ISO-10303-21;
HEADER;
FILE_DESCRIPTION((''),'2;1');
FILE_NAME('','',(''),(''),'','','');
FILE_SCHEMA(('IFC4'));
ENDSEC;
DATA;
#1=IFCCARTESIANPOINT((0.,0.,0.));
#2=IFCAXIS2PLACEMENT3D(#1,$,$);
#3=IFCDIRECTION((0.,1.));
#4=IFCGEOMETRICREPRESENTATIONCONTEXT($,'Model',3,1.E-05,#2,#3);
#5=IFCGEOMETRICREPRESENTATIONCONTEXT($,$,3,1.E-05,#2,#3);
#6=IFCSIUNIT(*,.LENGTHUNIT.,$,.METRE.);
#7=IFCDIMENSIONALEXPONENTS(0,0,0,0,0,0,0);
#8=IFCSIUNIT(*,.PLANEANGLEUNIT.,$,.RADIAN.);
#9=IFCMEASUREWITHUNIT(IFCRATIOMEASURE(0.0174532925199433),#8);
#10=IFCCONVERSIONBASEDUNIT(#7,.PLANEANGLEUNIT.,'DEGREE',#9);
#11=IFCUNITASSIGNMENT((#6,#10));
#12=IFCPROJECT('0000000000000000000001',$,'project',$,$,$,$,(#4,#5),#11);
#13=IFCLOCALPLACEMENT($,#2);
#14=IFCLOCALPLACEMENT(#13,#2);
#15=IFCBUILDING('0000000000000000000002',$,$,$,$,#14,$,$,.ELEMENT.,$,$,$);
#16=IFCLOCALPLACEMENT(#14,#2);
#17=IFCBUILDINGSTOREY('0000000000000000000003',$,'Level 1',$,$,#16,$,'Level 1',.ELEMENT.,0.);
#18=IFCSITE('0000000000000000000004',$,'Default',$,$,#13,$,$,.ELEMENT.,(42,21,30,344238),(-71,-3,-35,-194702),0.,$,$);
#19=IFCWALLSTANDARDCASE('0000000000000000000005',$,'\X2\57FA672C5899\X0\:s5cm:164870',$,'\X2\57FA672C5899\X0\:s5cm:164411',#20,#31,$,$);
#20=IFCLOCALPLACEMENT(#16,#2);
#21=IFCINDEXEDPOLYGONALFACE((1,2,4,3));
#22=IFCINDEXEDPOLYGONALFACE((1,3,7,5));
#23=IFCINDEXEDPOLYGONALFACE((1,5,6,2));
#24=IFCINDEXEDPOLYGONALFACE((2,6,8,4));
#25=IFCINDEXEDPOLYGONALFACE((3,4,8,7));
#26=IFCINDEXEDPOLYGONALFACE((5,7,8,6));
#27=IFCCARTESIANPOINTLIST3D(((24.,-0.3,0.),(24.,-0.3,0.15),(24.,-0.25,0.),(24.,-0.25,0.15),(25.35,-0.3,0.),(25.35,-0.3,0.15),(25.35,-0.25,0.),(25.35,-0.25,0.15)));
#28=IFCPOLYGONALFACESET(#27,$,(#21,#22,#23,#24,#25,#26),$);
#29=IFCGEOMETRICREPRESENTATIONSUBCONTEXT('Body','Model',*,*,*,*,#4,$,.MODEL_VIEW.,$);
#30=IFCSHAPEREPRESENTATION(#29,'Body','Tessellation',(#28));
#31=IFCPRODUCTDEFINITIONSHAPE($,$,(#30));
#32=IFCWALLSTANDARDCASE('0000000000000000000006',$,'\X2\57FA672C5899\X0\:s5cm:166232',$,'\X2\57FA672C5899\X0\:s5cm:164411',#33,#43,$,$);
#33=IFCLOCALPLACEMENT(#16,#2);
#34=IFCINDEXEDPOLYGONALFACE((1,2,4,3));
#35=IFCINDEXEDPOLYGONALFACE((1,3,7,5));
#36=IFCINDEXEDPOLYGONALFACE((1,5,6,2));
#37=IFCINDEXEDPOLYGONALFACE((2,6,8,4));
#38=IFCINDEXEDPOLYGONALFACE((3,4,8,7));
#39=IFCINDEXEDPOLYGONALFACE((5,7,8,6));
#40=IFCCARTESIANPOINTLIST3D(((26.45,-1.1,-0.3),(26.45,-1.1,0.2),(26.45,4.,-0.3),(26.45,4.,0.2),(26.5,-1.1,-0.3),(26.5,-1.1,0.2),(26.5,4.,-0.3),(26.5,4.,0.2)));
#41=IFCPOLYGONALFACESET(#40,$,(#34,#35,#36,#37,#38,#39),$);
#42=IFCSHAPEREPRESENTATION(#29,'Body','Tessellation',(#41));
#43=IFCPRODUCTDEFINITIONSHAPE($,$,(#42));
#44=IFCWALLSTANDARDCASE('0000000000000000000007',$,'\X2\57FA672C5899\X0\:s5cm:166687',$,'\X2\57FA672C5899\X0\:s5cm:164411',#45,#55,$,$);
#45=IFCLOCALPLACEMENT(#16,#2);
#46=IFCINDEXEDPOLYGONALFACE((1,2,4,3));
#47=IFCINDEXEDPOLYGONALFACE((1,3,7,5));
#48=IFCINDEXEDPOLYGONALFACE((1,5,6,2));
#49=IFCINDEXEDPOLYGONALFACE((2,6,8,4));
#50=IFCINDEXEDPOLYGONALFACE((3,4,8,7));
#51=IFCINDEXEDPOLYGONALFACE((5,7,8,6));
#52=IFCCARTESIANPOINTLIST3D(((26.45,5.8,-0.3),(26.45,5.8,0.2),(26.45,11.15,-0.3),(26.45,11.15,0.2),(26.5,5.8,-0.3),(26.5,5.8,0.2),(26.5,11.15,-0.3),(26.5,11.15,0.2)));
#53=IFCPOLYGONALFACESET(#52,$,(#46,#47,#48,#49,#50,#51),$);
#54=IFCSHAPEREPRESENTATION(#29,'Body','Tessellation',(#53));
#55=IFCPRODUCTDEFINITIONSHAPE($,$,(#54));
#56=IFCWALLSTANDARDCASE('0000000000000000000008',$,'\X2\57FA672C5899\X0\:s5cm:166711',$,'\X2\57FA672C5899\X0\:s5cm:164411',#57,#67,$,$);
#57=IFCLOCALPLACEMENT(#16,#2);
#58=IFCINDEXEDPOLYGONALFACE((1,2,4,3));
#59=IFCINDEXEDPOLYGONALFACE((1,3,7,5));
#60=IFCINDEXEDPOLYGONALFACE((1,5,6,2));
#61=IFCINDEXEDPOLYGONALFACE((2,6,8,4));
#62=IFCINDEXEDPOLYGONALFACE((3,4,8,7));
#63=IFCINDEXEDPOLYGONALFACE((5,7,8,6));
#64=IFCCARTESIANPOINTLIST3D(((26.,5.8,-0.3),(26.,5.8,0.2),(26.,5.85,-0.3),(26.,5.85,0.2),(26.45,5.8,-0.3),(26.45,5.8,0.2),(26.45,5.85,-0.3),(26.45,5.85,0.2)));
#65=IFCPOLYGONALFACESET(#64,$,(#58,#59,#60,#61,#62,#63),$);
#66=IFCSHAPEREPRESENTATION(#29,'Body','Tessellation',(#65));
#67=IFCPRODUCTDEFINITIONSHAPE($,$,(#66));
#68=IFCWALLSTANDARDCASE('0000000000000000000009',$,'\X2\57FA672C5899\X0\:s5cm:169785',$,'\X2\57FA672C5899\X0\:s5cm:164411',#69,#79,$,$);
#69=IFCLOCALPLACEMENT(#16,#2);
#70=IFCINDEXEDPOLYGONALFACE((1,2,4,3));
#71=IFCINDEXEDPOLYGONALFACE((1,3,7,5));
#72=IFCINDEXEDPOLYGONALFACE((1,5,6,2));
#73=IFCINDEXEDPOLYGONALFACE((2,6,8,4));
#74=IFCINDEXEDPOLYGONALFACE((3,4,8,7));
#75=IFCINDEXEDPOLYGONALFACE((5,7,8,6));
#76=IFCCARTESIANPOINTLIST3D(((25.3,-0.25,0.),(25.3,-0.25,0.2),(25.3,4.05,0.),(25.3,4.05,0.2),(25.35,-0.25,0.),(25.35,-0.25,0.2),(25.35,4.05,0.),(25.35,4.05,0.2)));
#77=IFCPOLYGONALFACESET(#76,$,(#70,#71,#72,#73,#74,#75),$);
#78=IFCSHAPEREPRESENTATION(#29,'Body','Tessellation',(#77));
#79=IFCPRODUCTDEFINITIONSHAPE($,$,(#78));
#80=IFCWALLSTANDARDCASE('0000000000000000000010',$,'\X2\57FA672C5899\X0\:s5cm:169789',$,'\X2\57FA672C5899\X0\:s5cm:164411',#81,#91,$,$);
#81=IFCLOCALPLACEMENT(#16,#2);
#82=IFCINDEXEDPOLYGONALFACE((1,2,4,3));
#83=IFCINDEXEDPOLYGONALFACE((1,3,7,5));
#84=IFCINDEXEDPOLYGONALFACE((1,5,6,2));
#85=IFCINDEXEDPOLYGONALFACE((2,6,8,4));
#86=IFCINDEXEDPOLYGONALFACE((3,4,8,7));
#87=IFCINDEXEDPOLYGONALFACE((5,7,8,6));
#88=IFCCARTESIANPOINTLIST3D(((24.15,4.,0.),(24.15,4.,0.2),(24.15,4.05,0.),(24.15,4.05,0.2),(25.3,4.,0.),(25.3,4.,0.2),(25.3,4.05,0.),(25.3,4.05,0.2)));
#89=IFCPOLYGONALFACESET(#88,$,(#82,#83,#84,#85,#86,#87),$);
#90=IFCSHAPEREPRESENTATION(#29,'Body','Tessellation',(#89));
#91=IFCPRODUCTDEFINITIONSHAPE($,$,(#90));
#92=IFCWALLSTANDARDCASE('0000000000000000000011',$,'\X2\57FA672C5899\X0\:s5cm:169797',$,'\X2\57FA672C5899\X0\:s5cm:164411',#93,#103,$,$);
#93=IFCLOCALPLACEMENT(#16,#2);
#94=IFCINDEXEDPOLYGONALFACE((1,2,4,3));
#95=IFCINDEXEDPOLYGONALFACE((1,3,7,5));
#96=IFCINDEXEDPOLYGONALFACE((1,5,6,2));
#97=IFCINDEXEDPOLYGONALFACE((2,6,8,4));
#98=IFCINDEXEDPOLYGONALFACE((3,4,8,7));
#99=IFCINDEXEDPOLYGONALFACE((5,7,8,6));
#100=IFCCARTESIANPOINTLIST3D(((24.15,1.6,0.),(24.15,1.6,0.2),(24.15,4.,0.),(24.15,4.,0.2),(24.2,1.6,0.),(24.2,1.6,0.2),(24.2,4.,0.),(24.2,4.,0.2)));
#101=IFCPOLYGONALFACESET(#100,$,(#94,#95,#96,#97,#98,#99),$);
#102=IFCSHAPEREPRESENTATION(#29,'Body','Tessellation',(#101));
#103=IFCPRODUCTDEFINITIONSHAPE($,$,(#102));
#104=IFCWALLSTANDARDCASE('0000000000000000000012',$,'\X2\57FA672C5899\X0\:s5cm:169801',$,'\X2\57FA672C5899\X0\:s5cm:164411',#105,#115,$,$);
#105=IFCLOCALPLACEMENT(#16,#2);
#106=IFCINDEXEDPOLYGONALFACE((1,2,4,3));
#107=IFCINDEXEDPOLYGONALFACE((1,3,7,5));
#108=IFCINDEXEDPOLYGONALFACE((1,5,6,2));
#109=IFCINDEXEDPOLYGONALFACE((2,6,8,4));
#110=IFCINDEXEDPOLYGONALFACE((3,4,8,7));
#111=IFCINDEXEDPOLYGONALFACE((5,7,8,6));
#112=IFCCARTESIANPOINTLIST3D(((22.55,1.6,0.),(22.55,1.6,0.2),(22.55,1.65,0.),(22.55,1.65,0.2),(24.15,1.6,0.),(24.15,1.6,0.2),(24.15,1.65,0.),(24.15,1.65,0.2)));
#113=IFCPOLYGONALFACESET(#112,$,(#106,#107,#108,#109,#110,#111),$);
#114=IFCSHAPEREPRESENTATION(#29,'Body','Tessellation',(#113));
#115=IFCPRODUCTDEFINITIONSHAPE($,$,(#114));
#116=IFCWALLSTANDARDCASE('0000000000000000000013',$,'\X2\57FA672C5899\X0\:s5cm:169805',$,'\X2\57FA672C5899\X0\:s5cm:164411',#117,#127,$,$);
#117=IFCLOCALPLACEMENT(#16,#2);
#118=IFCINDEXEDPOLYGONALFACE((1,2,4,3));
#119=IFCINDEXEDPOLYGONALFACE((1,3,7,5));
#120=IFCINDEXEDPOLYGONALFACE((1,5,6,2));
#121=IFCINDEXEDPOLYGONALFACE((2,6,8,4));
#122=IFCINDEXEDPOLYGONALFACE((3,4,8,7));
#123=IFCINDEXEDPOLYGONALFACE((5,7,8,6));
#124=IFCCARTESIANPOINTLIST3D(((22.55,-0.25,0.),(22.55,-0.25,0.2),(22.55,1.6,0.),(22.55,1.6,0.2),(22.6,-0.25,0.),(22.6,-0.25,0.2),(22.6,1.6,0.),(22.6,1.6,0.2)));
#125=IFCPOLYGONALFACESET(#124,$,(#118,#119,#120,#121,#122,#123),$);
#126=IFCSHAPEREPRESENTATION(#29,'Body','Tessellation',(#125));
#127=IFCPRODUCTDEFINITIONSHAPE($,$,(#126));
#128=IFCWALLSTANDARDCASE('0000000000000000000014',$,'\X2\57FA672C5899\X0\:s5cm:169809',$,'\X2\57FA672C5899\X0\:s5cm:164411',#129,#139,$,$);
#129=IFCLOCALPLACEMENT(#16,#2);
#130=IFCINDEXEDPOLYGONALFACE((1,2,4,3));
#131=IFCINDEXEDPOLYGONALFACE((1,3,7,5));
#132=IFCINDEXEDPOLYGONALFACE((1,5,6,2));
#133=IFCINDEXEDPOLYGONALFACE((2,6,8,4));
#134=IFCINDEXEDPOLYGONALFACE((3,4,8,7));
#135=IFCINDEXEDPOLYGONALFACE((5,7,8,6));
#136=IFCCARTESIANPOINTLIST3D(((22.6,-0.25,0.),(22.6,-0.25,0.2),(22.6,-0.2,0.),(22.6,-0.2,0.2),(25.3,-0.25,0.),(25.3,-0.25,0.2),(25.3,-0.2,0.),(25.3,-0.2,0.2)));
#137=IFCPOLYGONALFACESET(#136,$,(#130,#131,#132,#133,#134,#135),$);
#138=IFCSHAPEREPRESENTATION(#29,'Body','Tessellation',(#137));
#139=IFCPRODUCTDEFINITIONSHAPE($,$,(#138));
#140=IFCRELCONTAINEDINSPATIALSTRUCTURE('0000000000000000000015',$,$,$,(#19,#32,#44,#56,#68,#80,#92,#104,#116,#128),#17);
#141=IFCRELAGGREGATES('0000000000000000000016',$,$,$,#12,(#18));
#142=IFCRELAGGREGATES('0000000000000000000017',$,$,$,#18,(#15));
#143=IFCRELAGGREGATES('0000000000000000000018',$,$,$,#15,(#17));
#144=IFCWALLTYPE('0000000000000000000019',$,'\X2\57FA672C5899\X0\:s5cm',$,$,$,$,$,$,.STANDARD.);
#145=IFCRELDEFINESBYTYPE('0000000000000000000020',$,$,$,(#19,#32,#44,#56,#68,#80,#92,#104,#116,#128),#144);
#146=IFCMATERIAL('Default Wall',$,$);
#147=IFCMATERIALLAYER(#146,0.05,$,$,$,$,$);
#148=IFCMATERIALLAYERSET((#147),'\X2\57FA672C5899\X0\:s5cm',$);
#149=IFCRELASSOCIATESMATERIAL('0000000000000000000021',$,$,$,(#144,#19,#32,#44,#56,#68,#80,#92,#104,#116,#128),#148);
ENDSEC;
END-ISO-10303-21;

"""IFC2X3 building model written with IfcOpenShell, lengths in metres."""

from ifc_helpers import new_model, entity, si_unit, converted_unit, direction, frame, frame_2d, origin, place, context, subcontext, project, spatial, rectangle, extrude, material, layer, layer_set, layer_usage, type_object, element, save


model = new_model("IFC2X3")

# Units and contexts
model_context = context("Model", 3, precision=1e-05, world=origin(), true_north=direction((0.0, 1.0)))
context_of_model = context(None, 3, precision=1e-05, world=origin(), true_north=direction((0.0, 1.0)))
body_context = subcontext(model_context, "Body", "Model", "MODEL_VIEW")
ifc_project = project(units=[si_unit("LENGTHUNIT", "METRE"), converted_unit("PLANEANGLEUNIT", "DEGREE", entity("IfcRatioMeasure", 0.0174532925199433), si_unit("PLANEANGLEUNIT", "RADIAN"), dimensions=[0, 0, 0, 0, 0, 0, 0])], contexts=[model_context, context_of_model])

# Site, building, storey
site_placement = place(None, origin())
site = spatial("IfcSite", under=ifc_project, at=site_placement, Name="Default", CompositionType="ELEMENT", RefLatitude=(42, 21, 30, 344238), RefLongitude=(-71, -3, -35, -194702), RefElevation=0.0)
building_placement = place(site_placement, origin())
building = spatial("IfcBuilding", under=site, at=building_placement, CompositionType="ELEMENT")
storey_placement = place(building_placement, origin())
storey = spatial("IfcBuildingStorey", under=building, at=storey_placement, Name="Level 1", LongName="Level 1", CompositionType="ELEMENT", Elevation=0.0)

# Walls
ifc_material = material(Name="Default Wall")
ifc_layer = layer(ifc_material, 0.05)
ifc_layer_set = layer_set([ifc_layer], Name="基本墙:s5cm")
wall_type = type_object("IfcWallType", Name="基本墙:s5cm", PredefinedType="STANDARD", material=ifc_layer_set)
ifc_layer_usage_1 = layer_usage(ifc_layer_set, "AXIS2", "POSITIVE", -0.025)
wall_1_placement = place(storey_placement, frame((25.35, -0.275, 0.0), z_axis=(0.0, 0.0, 1.0), x_axis=(-1.0, 0.0, 0.0)))
element("IfcWallStandardCase", 1, at=wall_1_placement, inside=storey, type_object=wall_type, material=ifc_layer_usage_1, Name="基本墙:s5cm:164870", ObjectType="基本墙:s5cm:164411", context=body_context, shape_type="SweptSolid", body=[
    extrude(rectangle(XDim=1.35, YDim=0.05, at=frame_2d((0.675, 0.0), x_axis=(-1.0, 0.0))), origin(), (0.0, 0.0, 1.0), 0.15),
])
ifc_layer_usage_2 = layer_usage(ifc_layer_set, "AXIS2", "NEGATIVE", 0.025)
wall_2_placement = place(storey_placement, frame((26.475, -1.1, -0.3), z_axis=(0.0, 0.0, 1.0), x_axis=(0.0, 1.0, 0.0)))
element("IfcWallStandardCase", 2, at=wall_2_placement, inside=storey, type_object=wall_type, material=ifc_layer_usage_2, Name="基本墙:s5cm:166232", ObjectType="基本墙:s5cm:164411", context=body_context, shape_type="SweptSolid", body=[
    extrude(rectangle(XDim=5.1, YDim=0.05, at=frame_2d((2.55, 0.0), x_axis=(-1.0, 0.0))), origin(), (0.0, 0.0, 1.0), 0.5),
])
ifc_layer_usage_3 = layer_usage(ifc_layer_set, "AXIS2", "NEGATIVE", 0.025)
wall_3_placement = place(storey_placement, frame((26.475, 5.8, -0.3), z_axis=(0.0, 0.0, 1.0), x_axis=(0.0, 1.0, 0.0)))
element("IfcWallStandardCase", 3, at=wall_3_placement, inside=storey, type_object=wall_type, material=ifc_layer_usage_3, Name="基本墙:s5cm:166687", ObjectType="基本墙:s5cm:164411", context=body_context, shape_type="SweptSolid", body=[
    extrude(rectangle(XDim=5.35, YDim=0.05, at=frame_2d((2.675, 0.0), x_axis=(-1.0, 0.0))), origin(), (0.0, 0.0, 1.0), 0.5),
])
ifc_layer_usage_4 = layer_usage(ifc_layer_set, "AXIS2", "NEGATIVE", 0.025)
wall_4_placement = place(storey_placement, frame((26.0, 5.825, -0.3)))
element("IfcWallStandardCase", 4, at=wall_4_placement, inside=storey, type_object=wall_type, material=ifc_layer_usage_4, Name="基本墙:s5cm:166711", ObjectType="基本墙:s5cm:164411", context=body_context, shape_type="SweptSolid", body=[
    extrude(rectangle(XDim=0.45, YDim=0.05, at=frame_2d((0.225, 0.0), x_axis=(-1.0, 0.0))), origin(), (0.0, 0.0, 1.0), 0.5),
])
ifc_layer_usage_5 = layer_usage(ifc_layer_set, "AXIS2", "NEGATIVE", 0.025)
wall_5_placement = place(storey_placement, frame((25.325, 4.05, 0.0), z_axis=(0.0, 0.0, 1.0), x_axis=(0.0, -1.0, 0.0)))
element("IfcWallStandardCase", 5, at=wall_5_placement, inside=storey, type_object=wall_type, material=ifc_layer_usage_5, Name="基本墙:s5cm:169785", ObjectType="基本墙:s5cm:164411", context=body_context, shape_type="SweptSolid", body=[
    extrude(rectangle(XDim=4.3, YDim=0.05, at=frame_2d((2.15, 0.0), x_axis=(-1.0, 0.0))), origin(), (0.0, 0.0, 1.0), 0.2),
])
ifc_layer_usage_6 = layer_usage(ifc_layer_set, "AXIS2", "NEGATIVE", 0.025)
wall_6_placement = place(storey_placement, frame((24.15, 4.025, 0.0)))
element("IfcWallStandardCase", 6, at=wall_6_placement, inside=storey, type_object=wall_type, material=ifc_layer_usage_6, Name="基本墙:s5cm:169789", ObjectType="基本墙:s5cm:164411", context=body_context, shape_type="SweptSolid", body=[
    extrude(rectangle(XDim=1.15, YDim=0.05, at=frame_2d((0.575, 0.0), x_axis=(-1.0, 0.0))), origin(), (0.0, 0.0, 1.0), 0.2),
])
ifc_layer_usage_7 = layer_usage(ifc_layer_set, "AXIS2", "NEGATIVE", 0.025)
wall_7_placement = place(storey_placement, frame((24.175, 4.0, 0.0), z_axis=(0.0, 0.0, 1.0), x_axis=(0.0, -1.0, 0.0)))
element("IfcWallStandardCase", 7, at=wall_7_placement, inside=storey, type_object=wall_type, material=ifc_layer_usage_7, Name="基本墙:s5cm:169797", ObjectType="基本墙:s5cm:164411", context=body_context, shape_type="SweptSolid", body=[
    extrude(rectangle(XDim=2.4, YDim=0.05, at=frame_2d((1.2, 0.0), x_axis=(-1.0, 0.0))), origin(), (0.0, 0.0, 1.0), 0.2),
])
ifc_layer_usage_8 = layer_usage(ifc_layer_set, "AXIS2", "POSITIVE", -0.025)
wall_8_placement = place(storey_placement, frame((24.15, 1.625, 0.0), z_axis=(0.0, 0.0, 1.0), x_axis=(-1.0, 0.0, 0.0)))
element("IfcWallStandardCase", 8, at=wall_8_placement, inside=storey, type_object=wall_type, material=ifc_layer_usage_8, Name="基本墙:s5cm:169801", ObjectType="基本墙:s5cm:164411", context=body_context, shape_type="SweptSolid", body=[
    extrude(rectangle(XDim=1.6, YDim=0.05, at=frame_2d((0.8, 0.0), x_axis=(-1.0, 0.0))), origin(), (0.0, 0.0, 1.0), 0.2),
])
ifc_layer_usage_9 = layer_usage(ifc_layer_set, "AXIS2", "POSITIVE", -0.025)
wall_9_placement = place(storey_placement, frame((22.575, 1.6, 0.0), z_axis=(0.0, 0.0, 1.0), x_axis=(0.0, -1.0, 0.0)))
element("IfcWallStandardCase", 9, at=wall_9_placement, inside=storey, type_object=wall_type, material=ifc_layer_usage_9, Name="基本墙:s5cm:169805", ObjectType="基本墙:s5cm:164411", context=body_context, shape_type="SweptSolid", body=[
    extrude(rectangle(XDim=1.85, YDim=0.05, at=frame_2d((0.925, 0.0), x_axis=(-1.0, 0.0))), origin(), (0.0, 0.0, 1.0), 0.2),
])
ifc_layer_usage_10 = layer_usage(ifc_layer_set, "AXIS2", "POSITIVE", -0.025)
wall_10_placement = place(storey_placement, frame((22.6, -0.225, 0.0)))
element("IfcWallStandardCase", 10, at=wall_10_placement, inside=storey, type_object=wall_type, material=ifc_layer_usage_10, Name="基本墙:s5cm:169809", ObjectType="基本墙:s5cm:164411", context=body_context, shape_type="SweptSolid", body=[
    extrude(rectangle(XDim=2.7, YDim=0.05, at=frame_2d((1.35, 0.0), x_axis=(-1.0, 0.0))), origin(), (0.0, 0.0, 1.0), 0.2),
])

save(model, "model.ifc")
